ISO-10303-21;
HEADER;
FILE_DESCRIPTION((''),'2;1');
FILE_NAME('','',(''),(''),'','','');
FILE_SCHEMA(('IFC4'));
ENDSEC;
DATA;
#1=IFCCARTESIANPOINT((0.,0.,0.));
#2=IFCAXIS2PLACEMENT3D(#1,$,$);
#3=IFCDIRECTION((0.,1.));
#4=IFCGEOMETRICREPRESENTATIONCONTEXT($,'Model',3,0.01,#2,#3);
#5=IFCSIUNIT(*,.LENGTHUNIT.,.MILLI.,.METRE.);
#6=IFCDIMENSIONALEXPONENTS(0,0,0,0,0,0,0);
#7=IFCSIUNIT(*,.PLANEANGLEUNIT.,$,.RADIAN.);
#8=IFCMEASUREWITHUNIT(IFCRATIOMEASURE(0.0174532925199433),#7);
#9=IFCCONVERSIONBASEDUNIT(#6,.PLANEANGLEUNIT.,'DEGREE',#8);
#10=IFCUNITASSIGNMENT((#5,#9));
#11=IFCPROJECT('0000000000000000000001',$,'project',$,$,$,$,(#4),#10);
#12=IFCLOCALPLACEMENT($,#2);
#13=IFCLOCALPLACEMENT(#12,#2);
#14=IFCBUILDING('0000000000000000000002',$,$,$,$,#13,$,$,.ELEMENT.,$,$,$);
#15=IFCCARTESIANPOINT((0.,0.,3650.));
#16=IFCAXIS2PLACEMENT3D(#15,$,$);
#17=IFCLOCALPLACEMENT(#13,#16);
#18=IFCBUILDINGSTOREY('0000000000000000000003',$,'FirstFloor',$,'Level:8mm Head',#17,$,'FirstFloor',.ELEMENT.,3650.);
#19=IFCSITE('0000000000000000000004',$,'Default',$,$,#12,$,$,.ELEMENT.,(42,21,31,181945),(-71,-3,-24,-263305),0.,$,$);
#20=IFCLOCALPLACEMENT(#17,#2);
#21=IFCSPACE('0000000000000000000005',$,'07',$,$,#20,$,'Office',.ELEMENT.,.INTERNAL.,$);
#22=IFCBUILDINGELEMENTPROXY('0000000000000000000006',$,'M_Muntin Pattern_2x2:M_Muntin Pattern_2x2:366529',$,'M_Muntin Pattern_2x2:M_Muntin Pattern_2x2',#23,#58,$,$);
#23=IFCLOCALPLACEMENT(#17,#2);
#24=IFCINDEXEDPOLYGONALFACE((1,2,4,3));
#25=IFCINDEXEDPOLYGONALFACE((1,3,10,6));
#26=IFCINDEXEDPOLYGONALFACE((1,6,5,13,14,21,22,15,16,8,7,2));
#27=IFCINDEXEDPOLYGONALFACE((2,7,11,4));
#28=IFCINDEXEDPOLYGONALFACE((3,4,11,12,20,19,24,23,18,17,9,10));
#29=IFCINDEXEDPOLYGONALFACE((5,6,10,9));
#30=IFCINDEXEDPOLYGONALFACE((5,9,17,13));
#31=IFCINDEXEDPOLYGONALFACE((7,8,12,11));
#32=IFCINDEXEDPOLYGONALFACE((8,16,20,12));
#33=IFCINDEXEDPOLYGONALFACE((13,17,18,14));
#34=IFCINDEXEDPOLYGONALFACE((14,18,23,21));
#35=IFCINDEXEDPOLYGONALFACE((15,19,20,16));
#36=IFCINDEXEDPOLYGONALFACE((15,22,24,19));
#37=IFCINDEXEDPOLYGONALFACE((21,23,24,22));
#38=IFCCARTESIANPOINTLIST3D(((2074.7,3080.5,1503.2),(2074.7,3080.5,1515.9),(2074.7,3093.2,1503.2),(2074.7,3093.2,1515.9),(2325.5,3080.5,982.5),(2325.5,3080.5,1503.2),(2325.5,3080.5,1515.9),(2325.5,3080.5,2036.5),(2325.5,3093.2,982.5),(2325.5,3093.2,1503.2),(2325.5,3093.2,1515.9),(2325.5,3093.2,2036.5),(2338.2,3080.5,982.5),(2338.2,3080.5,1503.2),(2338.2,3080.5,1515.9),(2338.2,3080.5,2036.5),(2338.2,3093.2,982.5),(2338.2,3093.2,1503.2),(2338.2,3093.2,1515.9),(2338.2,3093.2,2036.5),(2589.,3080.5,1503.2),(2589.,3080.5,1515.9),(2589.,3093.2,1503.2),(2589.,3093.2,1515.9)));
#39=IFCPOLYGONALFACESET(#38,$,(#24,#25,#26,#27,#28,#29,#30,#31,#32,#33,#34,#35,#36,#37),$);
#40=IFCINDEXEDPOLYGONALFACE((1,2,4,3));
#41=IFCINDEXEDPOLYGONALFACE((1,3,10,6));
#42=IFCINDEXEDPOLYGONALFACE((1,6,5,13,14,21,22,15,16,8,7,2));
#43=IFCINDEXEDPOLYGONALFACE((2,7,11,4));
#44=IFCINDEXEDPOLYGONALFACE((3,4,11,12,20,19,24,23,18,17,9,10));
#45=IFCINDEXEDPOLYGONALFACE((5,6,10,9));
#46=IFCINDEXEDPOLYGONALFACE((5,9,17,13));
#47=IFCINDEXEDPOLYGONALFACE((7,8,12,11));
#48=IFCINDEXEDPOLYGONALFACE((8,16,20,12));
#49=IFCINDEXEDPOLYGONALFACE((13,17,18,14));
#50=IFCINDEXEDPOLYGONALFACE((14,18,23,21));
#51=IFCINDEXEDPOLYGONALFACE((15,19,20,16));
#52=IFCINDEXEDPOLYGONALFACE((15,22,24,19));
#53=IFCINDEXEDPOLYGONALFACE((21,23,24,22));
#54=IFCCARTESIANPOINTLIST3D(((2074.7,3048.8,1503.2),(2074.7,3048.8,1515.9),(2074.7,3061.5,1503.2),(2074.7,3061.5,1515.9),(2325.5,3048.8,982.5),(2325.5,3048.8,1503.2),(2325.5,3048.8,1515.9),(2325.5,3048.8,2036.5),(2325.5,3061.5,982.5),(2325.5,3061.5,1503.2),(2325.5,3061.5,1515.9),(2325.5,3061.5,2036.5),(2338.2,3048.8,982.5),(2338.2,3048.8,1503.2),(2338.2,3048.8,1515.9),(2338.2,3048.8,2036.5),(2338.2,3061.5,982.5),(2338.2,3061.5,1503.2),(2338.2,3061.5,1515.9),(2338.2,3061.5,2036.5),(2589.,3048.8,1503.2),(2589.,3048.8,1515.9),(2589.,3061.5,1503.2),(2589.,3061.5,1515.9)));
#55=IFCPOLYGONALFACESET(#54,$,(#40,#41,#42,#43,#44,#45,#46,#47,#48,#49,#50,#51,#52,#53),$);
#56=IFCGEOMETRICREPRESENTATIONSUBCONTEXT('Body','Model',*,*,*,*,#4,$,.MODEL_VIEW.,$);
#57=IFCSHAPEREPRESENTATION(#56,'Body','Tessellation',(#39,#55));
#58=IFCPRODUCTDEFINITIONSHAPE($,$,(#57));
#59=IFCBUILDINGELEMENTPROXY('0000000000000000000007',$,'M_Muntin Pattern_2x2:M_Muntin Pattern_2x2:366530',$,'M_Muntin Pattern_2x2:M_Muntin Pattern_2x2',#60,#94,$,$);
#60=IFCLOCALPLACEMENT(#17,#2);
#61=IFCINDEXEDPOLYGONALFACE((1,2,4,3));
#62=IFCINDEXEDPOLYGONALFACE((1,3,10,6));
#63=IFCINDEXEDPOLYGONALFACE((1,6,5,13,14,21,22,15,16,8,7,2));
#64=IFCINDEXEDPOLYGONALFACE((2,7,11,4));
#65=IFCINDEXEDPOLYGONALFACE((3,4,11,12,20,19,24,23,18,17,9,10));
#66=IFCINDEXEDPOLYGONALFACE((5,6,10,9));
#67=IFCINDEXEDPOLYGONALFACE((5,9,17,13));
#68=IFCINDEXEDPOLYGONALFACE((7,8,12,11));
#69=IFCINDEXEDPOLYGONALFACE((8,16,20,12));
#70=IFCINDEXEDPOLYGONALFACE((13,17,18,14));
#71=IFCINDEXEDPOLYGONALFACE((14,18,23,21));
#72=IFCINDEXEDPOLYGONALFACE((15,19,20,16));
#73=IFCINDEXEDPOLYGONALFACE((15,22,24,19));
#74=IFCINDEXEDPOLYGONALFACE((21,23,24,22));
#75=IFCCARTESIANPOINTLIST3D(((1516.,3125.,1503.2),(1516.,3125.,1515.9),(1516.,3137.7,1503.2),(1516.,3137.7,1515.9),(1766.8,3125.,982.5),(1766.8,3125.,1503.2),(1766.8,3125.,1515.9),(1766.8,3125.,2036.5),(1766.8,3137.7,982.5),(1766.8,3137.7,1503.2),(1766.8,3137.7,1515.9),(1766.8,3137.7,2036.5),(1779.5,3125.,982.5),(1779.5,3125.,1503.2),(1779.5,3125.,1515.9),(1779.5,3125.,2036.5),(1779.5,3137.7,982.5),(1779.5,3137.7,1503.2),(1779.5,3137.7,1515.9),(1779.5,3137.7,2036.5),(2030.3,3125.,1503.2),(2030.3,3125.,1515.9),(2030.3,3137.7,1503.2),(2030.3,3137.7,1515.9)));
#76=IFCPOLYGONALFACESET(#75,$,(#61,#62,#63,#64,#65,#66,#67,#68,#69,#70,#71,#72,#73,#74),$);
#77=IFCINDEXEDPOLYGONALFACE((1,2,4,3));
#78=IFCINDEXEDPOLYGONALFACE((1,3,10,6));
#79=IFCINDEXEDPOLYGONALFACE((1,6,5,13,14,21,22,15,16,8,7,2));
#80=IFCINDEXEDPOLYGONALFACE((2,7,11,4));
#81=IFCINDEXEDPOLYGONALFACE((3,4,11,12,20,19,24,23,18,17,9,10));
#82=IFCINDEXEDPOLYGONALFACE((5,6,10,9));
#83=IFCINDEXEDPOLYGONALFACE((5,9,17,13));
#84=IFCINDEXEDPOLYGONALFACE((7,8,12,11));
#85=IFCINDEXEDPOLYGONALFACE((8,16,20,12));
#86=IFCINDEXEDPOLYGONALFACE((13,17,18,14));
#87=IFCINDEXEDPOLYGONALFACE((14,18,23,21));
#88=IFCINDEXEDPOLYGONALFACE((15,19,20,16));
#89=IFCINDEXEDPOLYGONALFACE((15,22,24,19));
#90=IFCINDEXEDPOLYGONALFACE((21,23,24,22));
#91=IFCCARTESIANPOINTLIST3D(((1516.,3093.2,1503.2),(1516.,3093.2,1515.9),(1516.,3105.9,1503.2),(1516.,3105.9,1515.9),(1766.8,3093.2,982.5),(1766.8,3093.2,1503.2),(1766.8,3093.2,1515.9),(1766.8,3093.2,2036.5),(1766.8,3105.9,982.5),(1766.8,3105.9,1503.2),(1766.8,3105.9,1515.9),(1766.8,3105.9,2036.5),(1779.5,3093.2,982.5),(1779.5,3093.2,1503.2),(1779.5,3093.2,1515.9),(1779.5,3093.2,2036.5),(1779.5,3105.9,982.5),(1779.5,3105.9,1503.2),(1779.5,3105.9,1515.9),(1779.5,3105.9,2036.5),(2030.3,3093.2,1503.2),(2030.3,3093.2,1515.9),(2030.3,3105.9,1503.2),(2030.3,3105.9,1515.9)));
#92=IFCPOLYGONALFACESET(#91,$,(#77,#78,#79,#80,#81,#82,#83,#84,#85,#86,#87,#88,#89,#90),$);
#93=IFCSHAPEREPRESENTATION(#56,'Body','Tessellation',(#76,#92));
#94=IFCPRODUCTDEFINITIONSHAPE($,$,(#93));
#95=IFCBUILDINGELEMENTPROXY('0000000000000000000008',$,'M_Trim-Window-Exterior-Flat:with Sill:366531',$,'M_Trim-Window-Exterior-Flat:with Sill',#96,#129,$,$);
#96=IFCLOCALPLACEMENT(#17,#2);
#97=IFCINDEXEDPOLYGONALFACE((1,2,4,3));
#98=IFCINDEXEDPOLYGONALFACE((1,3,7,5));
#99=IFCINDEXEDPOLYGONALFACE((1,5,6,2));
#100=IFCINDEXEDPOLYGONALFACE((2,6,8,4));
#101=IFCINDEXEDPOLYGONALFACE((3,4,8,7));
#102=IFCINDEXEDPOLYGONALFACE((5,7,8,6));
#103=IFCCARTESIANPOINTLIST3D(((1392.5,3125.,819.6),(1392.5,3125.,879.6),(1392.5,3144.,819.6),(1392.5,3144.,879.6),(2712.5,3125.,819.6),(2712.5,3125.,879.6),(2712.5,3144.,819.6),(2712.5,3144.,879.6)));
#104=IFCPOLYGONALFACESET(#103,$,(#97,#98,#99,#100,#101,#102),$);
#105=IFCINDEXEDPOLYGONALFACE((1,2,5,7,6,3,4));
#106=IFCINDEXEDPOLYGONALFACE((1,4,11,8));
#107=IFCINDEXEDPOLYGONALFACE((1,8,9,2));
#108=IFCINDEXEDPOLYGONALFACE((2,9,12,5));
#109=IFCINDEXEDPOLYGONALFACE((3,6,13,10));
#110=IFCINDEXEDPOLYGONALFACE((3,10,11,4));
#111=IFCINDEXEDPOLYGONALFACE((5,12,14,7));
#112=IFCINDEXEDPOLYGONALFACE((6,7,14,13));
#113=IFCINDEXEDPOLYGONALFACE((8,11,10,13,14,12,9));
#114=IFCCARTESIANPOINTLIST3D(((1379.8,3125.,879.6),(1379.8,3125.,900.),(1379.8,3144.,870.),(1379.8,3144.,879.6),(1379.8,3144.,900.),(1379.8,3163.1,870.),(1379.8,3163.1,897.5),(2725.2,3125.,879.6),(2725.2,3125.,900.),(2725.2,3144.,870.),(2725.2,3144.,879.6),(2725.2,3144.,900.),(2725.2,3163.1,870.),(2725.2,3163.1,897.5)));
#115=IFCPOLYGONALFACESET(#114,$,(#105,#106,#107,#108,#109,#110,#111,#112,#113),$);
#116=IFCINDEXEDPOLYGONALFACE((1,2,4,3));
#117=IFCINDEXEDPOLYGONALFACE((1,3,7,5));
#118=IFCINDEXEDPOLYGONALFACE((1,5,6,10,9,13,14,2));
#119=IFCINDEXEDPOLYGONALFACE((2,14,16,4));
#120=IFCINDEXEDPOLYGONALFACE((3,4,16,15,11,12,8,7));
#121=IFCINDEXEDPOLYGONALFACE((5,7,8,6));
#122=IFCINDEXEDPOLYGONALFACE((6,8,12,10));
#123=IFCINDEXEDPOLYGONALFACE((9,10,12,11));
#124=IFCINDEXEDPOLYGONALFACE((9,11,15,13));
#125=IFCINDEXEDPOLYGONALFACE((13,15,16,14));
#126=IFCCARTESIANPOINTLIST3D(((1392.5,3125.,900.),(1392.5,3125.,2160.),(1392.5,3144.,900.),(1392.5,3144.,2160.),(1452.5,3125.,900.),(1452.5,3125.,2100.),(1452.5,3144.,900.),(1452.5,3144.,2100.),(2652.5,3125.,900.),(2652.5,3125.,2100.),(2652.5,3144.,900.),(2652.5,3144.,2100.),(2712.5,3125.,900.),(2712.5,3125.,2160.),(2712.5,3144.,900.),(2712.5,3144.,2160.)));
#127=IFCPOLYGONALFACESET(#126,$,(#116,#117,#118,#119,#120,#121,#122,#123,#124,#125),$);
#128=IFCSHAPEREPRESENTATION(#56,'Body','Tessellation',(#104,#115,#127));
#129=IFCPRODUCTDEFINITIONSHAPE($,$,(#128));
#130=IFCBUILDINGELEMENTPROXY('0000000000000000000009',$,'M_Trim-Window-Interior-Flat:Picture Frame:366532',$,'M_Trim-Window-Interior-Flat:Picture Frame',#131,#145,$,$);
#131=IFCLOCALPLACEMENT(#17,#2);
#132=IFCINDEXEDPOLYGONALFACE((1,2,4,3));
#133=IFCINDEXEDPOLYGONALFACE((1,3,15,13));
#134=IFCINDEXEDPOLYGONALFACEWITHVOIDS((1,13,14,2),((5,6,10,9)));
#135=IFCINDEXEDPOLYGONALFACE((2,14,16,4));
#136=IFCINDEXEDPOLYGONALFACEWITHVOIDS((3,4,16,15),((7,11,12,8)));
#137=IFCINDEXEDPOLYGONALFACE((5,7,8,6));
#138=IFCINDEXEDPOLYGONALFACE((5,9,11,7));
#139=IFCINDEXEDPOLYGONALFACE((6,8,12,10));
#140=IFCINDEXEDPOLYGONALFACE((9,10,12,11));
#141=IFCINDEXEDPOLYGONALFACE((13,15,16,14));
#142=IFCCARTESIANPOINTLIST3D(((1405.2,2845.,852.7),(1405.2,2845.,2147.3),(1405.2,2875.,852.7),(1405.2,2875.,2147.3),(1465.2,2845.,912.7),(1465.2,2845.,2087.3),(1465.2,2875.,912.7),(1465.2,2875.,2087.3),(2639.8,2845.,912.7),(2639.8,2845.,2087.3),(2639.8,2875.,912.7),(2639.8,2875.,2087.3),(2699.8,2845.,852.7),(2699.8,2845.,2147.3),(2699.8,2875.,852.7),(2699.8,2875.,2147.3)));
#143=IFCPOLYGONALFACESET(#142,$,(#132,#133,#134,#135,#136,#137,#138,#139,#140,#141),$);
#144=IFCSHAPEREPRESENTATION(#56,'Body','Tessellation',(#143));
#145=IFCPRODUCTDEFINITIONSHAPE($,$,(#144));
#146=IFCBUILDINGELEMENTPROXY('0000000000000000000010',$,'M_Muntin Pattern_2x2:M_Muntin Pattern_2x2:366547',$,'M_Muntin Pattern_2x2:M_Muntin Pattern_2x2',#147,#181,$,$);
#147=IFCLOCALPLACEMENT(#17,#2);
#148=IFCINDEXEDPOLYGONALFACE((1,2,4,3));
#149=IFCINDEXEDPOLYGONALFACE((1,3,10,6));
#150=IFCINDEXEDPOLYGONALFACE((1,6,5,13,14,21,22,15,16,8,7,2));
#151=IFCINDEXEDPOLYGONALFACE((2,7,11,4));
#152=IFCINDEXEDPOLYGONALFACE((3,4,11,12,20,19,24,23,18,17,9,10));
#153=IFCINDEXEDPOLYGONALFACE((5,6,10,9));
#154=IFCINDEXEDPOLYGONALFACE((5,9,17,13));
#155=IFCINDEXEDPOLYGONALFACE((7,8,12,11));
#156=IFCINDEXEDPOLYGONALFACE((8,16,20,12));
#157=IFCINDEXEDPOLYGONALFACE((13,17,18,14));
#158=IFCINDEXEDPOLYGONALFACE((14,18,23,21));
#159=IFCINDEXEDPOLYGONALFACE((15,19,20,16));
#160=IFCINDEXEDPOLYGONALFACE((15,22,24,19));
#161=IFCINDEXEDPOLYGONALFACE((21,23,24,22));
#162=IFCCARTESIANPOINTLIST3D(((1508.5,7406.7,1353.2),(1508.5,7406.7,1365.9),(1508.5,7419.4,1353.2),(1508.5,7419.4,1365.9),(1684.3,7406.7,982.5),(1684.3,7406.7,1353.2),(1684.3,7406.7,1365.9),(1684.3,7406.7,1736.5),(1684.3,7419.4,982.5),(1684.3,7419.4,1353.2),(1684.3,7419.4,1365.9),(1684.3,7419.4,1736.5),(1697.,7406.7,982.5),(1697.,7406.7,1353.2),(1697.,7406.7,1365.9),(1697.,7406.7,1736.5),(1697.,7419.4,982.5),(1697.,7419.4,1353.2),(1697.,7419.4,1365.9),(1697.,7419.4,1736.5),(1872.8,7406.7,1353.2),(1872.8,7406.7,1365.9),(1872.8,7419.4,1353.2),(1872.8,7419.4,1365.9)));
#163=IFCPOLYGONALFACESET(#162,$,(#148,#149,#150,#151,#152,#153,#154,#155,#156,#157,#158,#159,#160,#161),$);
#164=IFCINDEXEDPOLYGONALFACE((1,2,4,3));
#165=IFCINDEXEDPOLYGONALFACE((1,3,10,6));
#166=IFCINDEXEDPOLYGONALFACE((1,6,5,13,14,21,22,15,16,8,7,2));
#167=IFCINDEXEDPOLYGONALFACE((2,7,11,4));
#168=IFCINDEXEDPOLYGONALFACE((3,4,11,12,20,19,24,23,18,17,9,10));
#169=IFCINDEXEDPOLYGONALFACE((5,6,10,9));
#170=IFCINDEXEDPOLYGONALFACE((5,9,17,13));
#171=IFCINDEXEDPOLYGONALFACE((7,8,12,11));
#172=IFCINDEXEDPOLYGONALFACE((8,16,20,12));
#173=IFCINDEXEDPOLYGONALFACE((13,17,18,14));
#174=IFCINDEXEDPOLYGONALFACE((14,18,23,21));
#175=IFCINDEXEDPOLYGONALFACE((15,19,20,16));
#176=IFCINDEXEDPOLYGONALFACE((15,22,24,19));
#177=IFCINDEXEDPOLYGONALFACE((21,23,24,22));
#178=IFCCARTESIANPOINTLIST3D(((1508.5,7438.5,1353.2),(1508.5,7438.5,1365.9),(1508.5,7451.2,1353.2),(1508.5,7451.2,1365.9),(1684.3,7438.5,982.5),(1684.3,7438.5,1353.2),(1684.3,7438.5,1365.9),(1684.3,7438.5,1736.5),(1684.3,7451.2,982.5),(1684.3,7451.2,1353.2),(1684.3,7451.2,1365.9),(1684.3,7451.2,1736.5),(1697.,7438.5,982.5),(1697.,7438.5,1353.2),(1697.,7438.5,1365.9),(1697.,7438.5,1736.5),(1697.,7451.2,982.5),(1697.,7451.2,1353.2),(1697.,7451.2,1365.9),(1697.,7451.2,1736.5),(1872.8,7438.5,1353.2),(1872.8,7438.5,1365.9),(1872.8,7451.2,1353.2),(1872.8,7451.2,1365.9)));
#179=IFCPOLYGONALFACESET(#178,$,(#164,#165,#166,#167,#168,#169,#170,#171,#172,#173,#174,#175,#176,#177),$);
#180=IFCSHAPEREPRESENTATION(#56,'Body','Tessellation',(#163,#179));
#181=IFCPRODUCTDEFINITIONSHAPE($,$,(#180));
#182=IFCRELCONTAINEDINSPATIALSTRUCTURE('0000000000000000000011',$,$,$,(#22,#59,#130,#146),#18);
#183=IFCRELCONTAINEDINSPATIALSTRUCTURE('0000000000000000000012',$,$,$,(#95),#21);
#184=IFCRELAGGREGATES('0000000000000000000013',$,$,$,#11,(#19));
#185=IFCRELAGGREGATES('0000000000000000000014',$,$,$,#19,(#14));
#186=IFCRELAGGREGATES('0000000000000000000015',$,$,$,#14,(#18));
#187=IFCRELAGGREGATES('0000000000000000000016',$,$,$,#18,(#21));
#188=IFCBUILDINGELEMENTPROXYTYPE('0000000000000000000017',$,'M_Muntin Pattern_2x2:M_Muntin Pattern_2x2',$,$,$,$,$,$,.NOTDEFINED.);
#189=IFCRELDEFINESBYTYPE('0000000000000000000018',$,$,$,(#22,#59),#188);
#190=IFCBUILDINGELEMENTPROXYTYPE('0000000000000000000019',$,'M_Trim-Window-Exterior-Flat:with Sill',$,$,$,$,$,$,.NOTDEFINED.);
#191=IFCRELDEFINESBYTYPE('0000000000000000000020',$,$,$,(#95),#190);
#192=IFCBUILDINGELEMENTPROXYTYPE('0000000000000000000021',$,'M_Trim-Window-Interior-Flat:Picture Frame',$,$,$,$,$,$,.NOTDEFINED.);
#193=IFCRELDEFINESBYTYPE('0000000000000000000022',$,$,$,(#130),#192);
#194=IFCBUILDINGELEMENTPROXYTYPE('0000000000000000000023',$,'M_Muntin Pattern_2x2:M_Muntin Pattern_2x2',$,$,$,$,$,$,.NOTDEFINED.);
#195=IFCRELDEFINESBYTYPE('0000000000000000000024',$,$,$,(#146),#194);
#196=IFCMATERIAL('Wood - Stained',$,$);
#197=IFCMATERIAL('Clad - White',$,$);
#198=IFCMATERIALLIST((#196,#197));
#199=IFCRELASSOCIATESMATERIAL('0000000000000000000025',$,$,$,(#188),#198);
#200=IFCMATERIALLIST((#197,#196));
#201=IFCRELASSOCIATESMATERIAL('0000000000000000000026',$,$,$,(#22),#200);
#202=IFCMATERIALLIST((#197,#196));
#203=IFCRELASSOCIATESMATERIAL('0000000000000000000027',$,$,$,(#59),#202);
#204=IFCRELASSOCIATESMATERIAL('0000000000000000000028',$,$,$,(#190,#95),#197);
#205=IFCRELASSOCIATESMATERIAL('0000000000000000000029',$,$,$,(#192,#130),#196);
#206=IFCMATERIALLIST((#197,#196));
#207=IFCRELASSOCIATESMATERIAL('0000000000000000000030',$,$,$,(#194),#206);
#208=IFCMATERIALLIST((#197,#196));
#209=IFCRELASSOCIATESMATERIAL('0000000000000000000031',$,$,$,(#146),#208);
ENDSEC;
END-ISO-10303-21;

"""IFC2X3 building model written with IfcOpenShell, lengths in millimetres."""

from ifc_helpers import new_model, entity, si_unit, converted_unit, direction, frame, frame_2d, origin, place, context, subcontext, project, spatial, polyline, rectangle, outline, extrude, source, transform, mapped, material, material_list, type_object, type_shapes, element, save


model = new_model("IFC2X3")

# Units and contexts
model_context = context("Model", 3, precision=0.01, world=origin(), true_north=direction((0.0, 1.0)))
body_context = subcontext(model_context, "Body", "Model", "MODEL_VIEW")
ifc_project = project(units=[si_unit("LENGTHUNIT", "METRE", prefix="MILLI"), converted_unit("PLANEANGLEUNIT", "DEGREE", entity("IfcRatioMeasure", 0.0174532925199433), si_unit("PLANEANGLEUNIT", "RADIAN"), dimensions=[0, 0, 0, 0, 0, 0, 0])], contexts=[model_context])

# Site, building, storey
site_placement = place(None, origin())
site = spatial("IfcSite", under=ifc_project, at=site_placement, Name="Default", CompositionType="ELEMENT", RefLatitude=(42, 21, 31, 181945), RefLongitude=(-71, -3, -24, -263305), RefElevation=0.0)
building_placement = place(site_placement, origin())
building = spatial("IfcBuilding", under=site, at=building_placement, CompositionType="ELEMENT")
storey_placement = place(building_placement, frame((0.0, 0.0, 3650.0)))
storey = spatial("IfcBuildingStorey", under=building, at=storey_placement, Name="FirstFloor", ObjectType="Level:8mm Head", LongName="FirstFloor", CompositionType="ELEMENT", Elevation=3650.0)

# Building element proxies
ifc_material_1 = material(Name="Clad - White")
ifc_material_2 = material(Name="Wood - Stained")
ifc_material_list_1 = material_list([ifc_material_1, ifc_material_2])
ifc_material_list_2 = material_list([ifc_material_2, ifc_material_1])
building_element_proxy_type_1 = type_object("IfcBuildingElementProxyType", Name="M_Muntin Pattern_2x2:M_Muntin Pattern_2x2", PredefinedType="NOTDEFINED", material=ifc_material_list_2)
shared_shape_1 = source(origin(), body_context, "Body", "SweptSolid", [
    extrude(outline(polyline([(6.4, -6.4), (527.0, -6.4), (527.0, 6.3), (6.4, 6.3), (6.4, 257.1), (-6.3, 257.1), (-6.3, 6.3), (-527.0, 6.3), (-527.0, -6.4), (-6.3, -6.4), (-6.3, -257.1), (6.4, -257.1), (6.4, -6.4)])), frame((0.0, 9.5, 527.0), z_axis=(0.0, 1.0, 0.0), x_axis=(0.0, 0.0, 1.0)), (0.0, 0.0, 1.0), 12.7),
    extrude(outline(polyline([(6.4, -6.4), (527.0, -6.4), (527.0, 6.3), (6.4, 6.3), (6.4, 257.1), (-6.3, 257.1), (-6.3, 6.3), (-527.0, 6.3), (-527.0, -6.4), (-6.3, -6.4), (-6.3, -257.1), (6.4, -257.1), (6.4, -6.4)])), frame((0.0, -22.2, 527.0), z_axis=(0.0, 1.0, 0.0), x_axis=(0.0, 0.0, 1.0)), (0.0, 0.0, 1.0), 12.7),
])
type_shapes(building_element_proxy_type_1, [shared_shape_1])
proxy_1_placement = place(storey_placement, frame((2331.9, 3071.0, 982.5)))
element("IfcBuildingElementProxy", 1, at=proxy_1_placement, inside=storey, type_object=building_element_proxy_type_1, material=ifc_material_list_1, Name="M_Muntin Pattern_2x2:M_Muntin Pattern_2x2:366529", ObjectType="M_Muntin Pattern_2x2:M_Muntin Pattern_2x2", context=body_context, shape_type="MappedRepresentation", body=[
    mapped(shared_shape_1, transform((0.0, 0.0, 0.0), scale=1.0)),
])
ifc_material_list_3 = material_list([ifc_material_1, ifc_material_2])
proxy_2_placement = place(storey_placement, frame((1773.1, 3115.5, 982.5)))
element("IfcBuildingElementProxy", 2, at=proxy_2_placement, inside=storey, type_object=building_element_proxy_type_1, material=ifc_material_list_3, Name="M_Muntin Pattern_2x2:M_Muntin Pattern_2x2:366530", ObjectType="M_Muntin Pattern_2x2:M_Muntin Pattern_2x2", context=body_context, shape_type="MappedRepresentation", body=[
    mapped(shared_shape_1, transform((0.0, 0.0, 0.0), scale=1.0)),
])

# Shared definitions
space_1_placement = place(storey_placement, origin())
space_1 = spatial("IfcSpace", under=storey, at=space_1_placement, Name="07", LongName="Office", CompositionType="ELEMENT", InteriorOrExteriorSpace="INTERNAL")

# Building element proxies
building_element_proxy_type_2 = type_object("IfcBuildingElementProxyType", Name="M_Trim-Window-Exterior-Flat:with Sill", PredefinedType="NOTDEFINED", material=ifc_material_1)
shared_shape_2 = source(origin(), body_context, "Body", "SweptSolid", [
    extrude(rectangle(XDim=1320.0, YDim=60.0, at=frame_2d((0.0, 0.0), x_axis=(1.0, 0.0))), frame((0.0, -1250.4, 0.0), z_axis=(0.0, 0.0, 1.0), x_axis=(-1.0, 0.0, 0.0)), (0.0, 0.0, 1.0), 19.1),
    extrude(outline(polyline([(-19.0, -15.2), (0.0, -15.2), (0.0, -5.7), (19.0, -5.7), (19.0, 14.8), (0.0, 14.8), (-19.0, 12.3), (-19.0, -15.2)])), frame((-672.7, -1214.8, 19.0), z_axis=(1.0, 0.0, 0.0), x_axis=(0.0, 0.0, -1.0)), (0.0, 0.0, 1.0), 1345.4),
    extrude(outline(polyline([(-645.0, -660.0), (615.0, -660.0), (615.0, -600.0), (-585.0, -600.0), (-585.0, 600.0), (615.0, 600.0), (615.0, 660.0), (-645.0, 660.0), (-645.0, -660.0)])), frame((0.0, -585.0, 0.0), z_axis=(0.0, 0.0, 1.0), x_axis=(0.0, -1.0, 0.0)), (0.0, 0.0, 1.0), 19.1),
])
type_shapes(building_element_proxy_type_2, [shared_shape_2])
proxy_3_placement = place(space_1_placement, frame((2052.5, 3125.0, 2100.0), z_axis=(0.0, 1.0, 0.0), x_axis=(-1.0, 0.0, 0.0)))
element("IfcBuildingElementProxy", 3, at=proxy_3_placement, inside=space_1, type_object=building_element_proxy_type_2, material=ifc_material_1, Name="M_Trim-Window-Exterior-Flat:with Sill:366531", ObjectType="M_Trim-Window-Exterior-Flat:with Sill", context=body_context, shape_type="MappedRepresentation", body=[
    mapped(shared_shape_2, transform((0.0, 0.0, 0.0), scale=1.0)),
])
building_element_proxy_type_3 = type_object("IfcBuildingElementProxyType", Name="M_Trim-Window-Interior-Flat:Picture Frame", PredefinedType="NOTDEFINED", material=ifc_material_2)
shared_shape_3 = source(origin(), body_context, "Body", "SweptSolid", [
    extrude(outline(polyline([(-647.3, -647.3), (647.3, -647.3), (647.3, 647.3), (-647.3, 647.3), (-647.3, -647.3)]), holes=[polyline([(-587.3, -587.3), (-587.3, 587.3), (587.3, 587.3), (587.3, -587.3), (-587.3, -587.3)])]), frame((0.0, -600.0, 0.0), z_axis=(0.0, 0.0, 1.0), x_axis=(-1.0, 0.0, 0.0)), (0.0, 0.0, 1.0), 30.0),
])
type_shapes(building_element_proxy_type_3, [shared_shape_3])
proxy_4_placement = place(storey_placement, frame((2052.5, 2875.0, 2100.0), z_axis=(0.0, -1.0, 0.0), x_axis=(1.0, 0.0, 0.0)))
element("IfcBuildingElementProxy", 4, at=proxy_4_placement, inside=storey, type_object=building_element_proxy_type_3, material=ifc_material_2, Name="M_Trim-Window-Interior-Flat:Picture Frame:366532", ObjectType="M_Trim-Window-Interior-Flat:Picture Frame", context=body_context, shape_type="MappedRepresentation", body=[
    mapped(shared_shape_3, transform((0.0, 0.0, 0.0), scale=1.0)),
])
ifc_material_list_4 = material_list([ifc_material_1, ifc_material_2])
ifc_material_list_5 = material_list([ifc_material_1, ifc_material_2])
building_element_proxy_type_4 = type_object("IfcBuildingElementProxyType", Name="M_Muntin Pattern_2x2:M_Muntin Pattern_2x2", PredefinedType="NOTDEFINED", material=ifc_material_list_5)
shared_shape_4 = source(origin(), body_context, "Body", "SweptSolid", [
    extrude(outline(polyline([(6.4, -6.4), (377.0, -6.4), (377.0, 6.3), (6.4, 6.3), (6.4, 182.1), (-6.3, 182.1), (-6.3, 6.3), (-377.0, 6.3), (-377.0, -6.4), (-6.3, -6.4), (-6.3, -182.1), (6.4, -182.1), (6.4, -6.4)])), frame((0.0, 9.5, 377.0), z_axis=(0.0, 1.0, 0.0), x_axis=(0.0, 0.0, 1.0)), (0.0, 0.0, 1.0), 12.7),
    extrude(outline(polyline([(6.4, -6.4), (377.0, -6.4), (377.0, 6.3), (6.4, 6.3), (6.4, 182.1), (-6.3, 182.1), (-6.3, 6.3), (-377.0, 6.3), (-377.0, -6.4), (-6.3, -6.4), (-6.3, -182.1), (6.4, -182.1), (6.4, -6.4)])), frame((0.0, -22.2, 377.0), z_axis=(0.0, 1.0, 0.0), x_axis=(0.0, 0.0, 1.0)), (0.0, 0.0, 1.0), 12.7),
])
type_shapes(building_element_proxy_type_4, [shared_shape_4])
proxy_5_placement = place(storey_placement, frame((1690.6, 7429.0, 982.5), z_axis=(0.0, 0.0, 1.0), x_axis=(-1.0, 0.0, 0.0)))
element("IfcBuildingElementProxy", 5, at=proxy_5_placement, inside=storey, type_object=building_element_proxy_type_4, material=ifc_material_list_4, Name="M_Muntin Pattern_2x2:M_Muntin Pattern_2x2:366547", ObjectType="M_Muntin Pattern_2x2:M_Muntin Pattern_2x2", context=body_context, shape_type="MappedRepresentation", body=[
    mapped(shared_shape_4, transform((0.0, 0.0, 0.0), scale=1.0)),
])

save(model, "model.ifc")
